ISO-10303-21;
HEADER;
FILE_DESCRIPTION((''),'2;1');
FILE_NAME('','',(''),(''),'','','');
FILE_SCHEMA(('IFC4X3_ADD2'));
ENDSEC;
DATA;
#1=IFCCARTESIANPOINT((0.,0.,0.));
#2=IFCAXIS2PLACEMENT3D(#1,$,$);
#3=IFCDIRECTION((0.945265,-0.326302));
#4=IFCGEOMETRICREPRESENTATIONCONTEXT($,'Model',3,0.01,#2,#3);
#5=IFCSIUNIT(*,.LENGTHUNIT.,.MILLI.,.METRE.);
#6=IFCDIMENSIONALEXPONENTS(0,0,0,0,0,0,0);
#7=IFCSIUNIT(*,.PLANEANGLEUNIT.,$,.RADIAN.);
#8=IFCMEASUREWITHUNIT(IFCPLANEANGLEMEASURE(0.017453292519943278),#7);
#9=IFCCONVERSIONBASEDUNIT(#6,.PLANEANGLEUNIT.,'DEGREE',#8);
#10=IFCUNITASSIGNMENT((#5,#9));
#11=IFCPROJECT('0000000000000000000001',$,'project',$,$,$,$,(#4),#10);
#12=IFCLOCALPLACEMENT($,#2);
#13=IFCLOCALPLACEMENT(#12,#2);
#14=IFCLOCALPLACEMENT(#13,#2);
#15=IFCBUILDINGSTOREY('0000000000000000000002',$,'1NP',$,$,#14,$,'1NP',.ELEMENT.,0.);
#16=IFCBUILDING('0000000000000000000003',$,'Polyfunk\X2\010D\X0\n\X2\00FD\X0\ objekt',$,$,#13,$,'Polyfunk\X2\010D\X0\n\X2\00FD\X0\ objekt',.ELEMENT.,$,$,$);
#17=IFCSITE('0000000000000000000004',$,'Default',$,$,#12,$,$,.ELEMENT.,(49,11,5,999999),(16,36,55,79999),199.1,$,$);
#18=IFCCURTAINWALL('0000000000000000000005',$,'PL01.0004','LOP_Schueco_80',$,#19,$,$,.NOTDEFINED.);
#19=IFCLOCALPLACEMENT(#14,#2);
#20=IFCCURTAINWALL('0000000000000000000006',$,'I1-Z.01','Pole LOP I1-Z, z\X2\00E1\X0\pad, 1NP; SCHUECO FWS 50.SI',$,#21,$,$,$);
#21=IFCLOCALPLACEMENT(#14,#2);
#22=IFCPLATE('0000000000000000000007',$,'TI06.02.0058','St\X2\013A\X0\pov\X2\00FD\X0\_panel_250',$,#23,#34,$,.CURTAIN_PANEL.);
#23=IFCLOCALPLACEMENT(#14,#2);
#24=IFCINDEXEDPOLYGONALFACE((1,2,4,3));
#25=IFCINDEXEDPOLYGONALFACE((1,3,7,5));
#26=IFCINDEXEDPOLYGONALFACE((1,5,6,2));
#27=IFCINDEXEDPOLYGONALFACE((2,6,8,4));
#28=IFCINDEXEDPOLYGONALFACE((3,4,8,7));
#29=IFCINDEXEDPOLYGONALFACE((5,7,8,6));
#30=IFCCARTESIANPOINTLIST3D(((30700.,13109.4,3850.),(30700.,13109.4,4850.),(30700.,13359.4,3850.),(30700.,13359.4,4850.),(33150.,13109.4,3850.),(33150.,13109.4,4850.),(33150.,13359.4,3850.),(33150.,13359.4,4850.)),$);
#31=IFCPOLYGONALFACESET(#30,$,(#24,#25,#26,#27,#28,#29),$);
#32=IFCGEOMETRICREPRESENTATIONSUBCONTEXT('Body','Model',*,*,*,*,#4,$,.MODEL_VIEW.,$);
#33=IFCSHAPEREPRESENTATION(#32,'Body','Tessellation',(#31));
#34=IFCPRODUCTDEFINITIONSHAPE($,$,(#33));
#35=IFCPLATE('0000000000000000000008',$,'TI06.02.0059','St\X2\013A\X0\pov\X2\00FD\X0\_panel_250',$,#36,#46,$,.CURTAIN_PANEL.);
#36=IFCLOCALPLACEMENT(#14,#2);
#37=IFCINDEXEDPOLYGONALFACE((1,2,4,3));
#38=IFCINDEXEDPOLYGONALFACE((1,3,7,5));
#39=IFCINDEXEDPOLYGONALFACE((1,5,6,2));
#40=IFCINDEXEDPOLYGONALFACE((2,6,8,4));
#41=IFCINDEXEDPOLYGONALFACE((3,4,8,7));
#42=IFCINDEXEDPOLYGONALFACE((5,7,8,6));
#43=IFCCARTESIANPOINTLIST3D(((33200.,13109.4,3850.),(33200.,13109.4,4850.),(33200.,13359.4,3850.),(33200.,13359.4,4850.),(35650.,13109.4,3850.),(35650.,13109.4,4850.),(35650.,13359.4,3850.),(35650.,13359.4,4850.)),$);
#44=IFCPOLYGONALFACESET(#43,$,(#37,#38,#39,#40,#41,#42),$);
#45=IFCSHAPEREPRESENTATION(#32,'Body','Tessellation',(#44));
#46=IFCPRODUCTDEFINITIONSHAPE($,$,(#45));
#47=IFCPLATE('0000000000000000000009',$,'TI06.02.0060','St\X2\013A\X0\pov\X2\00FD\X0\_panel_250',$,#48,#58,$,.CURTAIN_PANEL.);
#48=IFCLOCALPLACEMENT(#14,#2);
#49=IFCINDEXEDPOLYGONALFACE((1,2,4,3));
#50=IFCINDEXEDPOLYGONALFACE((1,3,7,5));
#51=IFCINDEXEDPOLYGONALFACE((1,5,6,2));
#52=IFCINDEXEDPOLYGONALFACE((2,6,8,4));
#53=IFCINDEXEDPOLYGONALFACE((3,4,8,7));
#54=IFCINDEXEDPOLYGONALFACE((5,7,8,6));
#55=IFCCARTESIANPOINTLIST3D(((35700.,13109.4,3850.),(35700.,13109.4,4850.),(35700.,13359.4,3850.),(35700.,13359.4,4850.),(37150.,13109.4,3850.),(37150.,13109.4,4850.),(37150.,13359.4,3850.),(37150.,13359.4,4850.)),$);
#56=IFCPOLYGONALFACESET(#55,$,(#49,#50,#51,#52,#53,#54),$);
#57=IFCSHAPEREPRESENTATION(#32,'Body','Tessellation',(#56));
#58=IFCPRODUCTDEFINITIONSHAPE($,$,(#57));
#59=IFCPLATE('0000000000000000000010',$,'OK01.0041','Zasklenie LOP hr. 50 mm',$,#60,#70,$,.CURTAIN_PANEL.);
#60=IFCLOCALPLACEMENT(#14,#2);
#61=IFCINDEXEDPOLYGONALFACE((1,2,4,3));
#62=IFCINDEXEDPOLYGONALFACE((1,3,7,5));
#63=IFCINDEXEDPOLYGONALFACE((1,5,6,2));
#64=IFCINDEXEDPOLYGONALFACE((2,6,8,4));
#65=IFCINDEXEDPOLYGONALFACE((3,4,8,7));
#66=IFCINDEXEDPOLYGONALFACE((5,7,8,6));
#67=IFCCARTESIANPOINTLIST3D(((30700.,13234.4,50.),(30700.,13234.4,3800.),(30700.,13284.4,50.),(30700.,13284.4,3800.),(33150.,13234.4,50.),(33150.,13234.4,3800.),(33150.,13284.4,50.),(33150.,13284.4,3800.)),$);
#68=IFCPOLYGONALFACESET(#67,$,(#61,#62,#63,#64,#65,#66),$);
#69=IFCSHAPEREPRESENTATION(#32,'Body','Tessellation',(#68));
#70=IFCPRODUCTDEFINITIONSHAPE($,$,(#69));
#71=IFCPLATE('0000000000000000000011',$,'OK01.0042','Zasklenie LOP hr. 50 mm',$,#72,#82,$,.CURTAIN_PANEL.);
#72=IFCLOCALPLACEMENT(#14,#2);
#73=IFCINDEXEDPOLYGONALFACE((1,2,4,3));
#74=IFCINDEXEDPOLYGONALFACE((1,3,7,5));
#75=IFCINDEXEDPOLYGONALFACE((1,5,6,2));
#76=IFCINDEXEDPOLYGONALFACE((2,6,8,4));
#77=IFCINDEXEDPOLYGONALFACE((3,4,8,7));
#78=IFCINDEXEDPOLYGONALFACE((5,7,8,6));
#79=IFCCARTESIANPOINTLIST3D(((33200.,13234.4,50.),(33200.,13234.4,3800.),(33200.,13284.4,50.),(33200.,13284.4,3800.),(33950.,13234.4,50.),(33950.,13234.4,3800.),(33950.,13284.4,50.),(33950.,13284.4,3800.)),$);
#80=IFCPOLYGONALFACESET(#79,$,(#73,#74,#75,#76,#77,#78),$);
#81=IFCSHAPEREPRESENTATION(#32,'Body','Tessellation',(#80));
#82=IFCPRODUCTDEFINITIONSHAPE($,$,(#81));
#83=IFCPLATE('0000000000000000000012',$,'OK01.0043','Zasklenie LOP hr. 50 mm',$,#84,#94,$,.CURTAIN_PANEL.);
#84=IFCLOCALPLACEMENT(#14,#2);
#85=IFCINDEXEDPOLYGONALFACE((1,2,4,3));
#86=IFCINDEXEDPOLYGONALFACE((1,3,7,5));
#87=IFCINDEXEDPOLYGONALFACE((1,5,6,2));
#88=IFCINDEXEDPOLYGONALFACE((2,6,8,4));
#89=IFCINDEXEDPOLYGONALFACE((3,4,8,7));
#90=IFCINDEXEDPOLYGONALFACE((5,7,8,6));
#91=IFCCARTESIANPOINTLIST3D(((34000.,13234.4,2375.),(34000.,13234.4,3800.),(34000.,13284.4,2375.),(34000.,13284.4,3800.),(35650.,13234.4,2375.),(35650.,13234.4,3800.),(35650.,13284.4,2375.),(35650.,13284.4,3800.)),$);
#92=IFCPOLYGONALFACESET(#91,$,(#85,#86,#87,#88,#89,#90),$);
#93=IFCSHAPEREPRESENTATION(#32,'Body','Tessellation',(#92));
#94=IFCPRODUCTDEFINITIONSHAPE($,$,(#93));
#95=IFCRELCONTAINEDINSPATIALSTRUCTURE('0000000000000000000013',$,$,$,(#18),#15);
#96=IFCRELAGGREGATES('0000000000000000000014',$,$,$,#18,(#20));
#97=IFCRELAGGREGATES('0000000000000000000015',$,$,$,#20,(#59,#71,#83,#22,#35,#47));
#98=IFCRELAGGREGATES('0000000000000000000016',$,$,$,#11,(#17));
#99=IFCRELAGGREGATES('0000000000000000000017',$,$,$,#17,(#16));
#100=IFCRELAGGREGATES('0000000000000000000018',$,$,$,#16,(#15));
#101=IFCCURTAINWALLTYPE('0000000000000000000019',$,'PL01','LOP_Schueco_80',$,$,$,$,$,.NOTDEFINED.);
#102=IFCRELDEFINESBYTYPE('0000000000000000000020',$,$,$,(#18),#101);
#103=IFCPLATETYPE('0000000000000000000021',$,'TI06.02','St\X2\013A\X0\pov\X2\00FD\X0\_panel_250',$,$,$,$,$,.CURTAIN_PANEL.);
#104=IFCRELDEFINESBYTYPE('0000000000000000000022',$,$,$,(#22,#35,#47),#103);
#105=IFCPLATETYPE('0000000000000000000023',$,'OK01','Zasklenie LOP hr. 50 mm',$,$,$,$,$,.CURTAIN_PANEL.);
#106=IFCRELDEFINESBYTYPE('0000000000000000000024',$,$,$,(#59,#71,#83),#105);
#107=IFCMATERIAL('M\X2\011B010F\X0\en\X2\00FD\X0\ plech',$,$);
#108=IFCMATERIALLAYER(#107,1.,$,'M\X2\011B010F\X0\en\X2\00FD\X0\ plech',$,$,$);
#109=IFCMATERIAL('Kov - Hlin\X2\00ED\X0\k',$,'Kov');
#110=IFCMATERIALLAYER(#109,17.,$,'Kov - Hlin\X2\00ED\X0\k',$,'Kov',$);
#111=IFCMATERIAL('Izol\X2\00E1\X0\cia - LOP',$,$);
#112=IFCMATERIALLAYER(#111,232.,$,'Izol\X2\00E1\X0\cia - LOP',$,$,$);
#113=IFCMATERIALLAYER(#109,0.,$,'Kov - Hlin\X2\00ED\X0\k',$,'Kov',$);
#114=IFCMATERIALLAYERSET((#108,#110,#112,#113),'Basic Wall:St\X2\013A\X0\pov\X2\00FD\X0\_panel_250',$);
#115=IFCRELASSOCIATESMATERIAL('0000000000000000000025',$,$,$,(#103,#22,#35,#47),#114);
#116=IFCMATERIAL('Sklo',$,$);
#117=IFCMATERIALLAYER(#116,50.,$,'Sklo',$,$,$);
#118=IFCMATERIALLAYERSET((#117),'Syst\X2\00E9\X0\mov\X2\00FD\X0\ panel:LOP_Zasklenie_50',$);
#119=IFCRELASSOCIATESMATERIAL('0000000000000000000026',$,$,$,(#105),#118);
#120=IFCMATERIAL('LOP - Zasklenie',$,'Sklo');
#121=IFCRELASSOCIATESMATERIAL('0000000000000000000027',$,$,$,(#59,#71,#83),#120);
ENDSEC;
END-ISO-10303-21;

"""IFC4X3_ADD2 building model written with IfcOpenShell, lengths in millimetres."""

from ifc_helpers import new_model, entity, si_unit, converted_unit, direction, frame, frame_2d, origin, origin_2d_with_axis, place, context, subcontext, project, spatial, rectangle, extrude, source, transform, mapped, material, layer, layer_set, layer_usage, type_object, type_shapes, element, aggregate, save


model = new_model("IFC4X3_ADD2")

# Units and contexts
model_context = context("Model", 3, precision=0.01, world=origin(), true_north=direction((0.945265, -0.326302)))
body_context = subcontext(model_context, "Body", "Model", "MODEL_VIEW")
ifc_project = project(units=[si_unit("LENGTHUNIT", "METRE", prefix="MILLI"), converted_unit("PLANEANGLEUNIT", "DEGREE", entity("IfcPlaneAngleMeasure", 0.017453292519943278), si_unit("PLANEANGLEUNIT", "RADIAN"), dimensions=[0, 0, 0, 0, 0, 0, 0])], contexts=[model_context])

# Site, building, storey
site_placement = place(None, origin())
site = spatial("IfcSite", under=ifc_project, at=site_placement, Name="Default", CompositionType="ELEMENT", RefLatitude=(49, 11, 5, 999999), RefLongitude=(16, 36, 55, 79999), RefElevation=199.1)
building_placement = place(site_placement, origin())
building = spatial("IfcBuilding", under=site, at=building_placement, Name="Polyfunkčný objekt", LongName="Polyfunkčný objekt", CompositionType="ELEMENT")
storey_placement = place(building_placement, origin())
storey = spatial("IfcBuildingStorey", under=building, at=storey_placement, Name="1NP", LongName="1NP", CompositionType="ELEMENT", Elevation=0.0)

# Curtain walls, plates
curtain_wall_type = type_object("IfcCurtainWallType", Name="PL01", Description="LOP_Schueco_80", PredefinedType="NOTDEFINED")
curtain_wall_1_placement = place(storey_placement, origin())
curtain_wall_1 = element("IfcCurtainWall", 1, at=curtain_wall_1_placement, inside=storey, type_object=curtain_wall_type, Name="PL01.0004", Description="LOP_Schueco_80", PredefinedType="NOTDEFINED")
curtain_wall_2 = element("IfcCurtainWall", 2, Name="I1-Z.01", Description="Pole LOP I1-Z, západ, 1NP; SCHUECO FWS 50.SI")
aggregate(curtain_wall_1, [curtain_wall_2])
ifc_material_1 = material(Name="Měďený plech")
ifc_layer_1 = layer(ifc_material_1, 1.0, Name="Měďený plech")
ifc_material_2 = material(Name="Kov - Hliník", Category="Kov")
ifc_layer_2 = layer(ifc_material_2, 17.0, Name="Kov - Hliník", Category="Kov")
ifc_material_3 = material(Name="Izolácia - LOP")
ifc_layer_3 = layer(ifc_material_3, 232.0, Name="Izolácia - LOP")
ifc_layer_4 = layer(ifc_material_2, 0.0, Name="Kov - Hliník", Category="Kov")
ifc_layer_set_1 = layer_set([ifc_layer_1, ifc_layer_2, ifc_layer_3, ifc_layer_4], Name="Basic Wall:Stĺpový_panel_250")
ifc_layer_usage_1 = layer_usage(ifc_layer_set_1, "AXIS2", "NEGATIVE", 125.0)
plate_type_1 = type_object("IfcPlateType", Name="TI06.02", Description="Stĺpový_panel_250", PredefinedType="CURTAIN_PANEL", material=ifc_layer_set_1)
plate_1_placement = place(storey_placement, frame((30700.0, 13234.4, 3850.0)))
plate_1 = element("IfcPlate", 3, at=plate_1_placement, type_object=plate_type_1, material=ifc_layer_usage_1, Name="TI06.02.0058", Description="Stĺpový_panel_250", PredefinedType="CURTAIN_PANEL", context=body_context, shape_type="SweptSolid", body=[
    extrude(rectangle(XDim=250.0, YDim=2450.0, at=frame_2d((0.0, 0.0), x_axis=(1.0, 0.0))), frame((1225.0, 0.0, 0.0), z_axis=(0.0, 0.0, 1.0), x_axis=(0.0, 1.0, 0.0)), (0.0, 0.0, 1.0), 1000.0),
])
ifc_layer_usage_2 = layer_usage(ifc_layer_set_1, "AXIS2", "NEGATIVE", 125.0)
plate_2_placement = place(storey_placement, frame((33200.0, 13234.4, 3850.0)))
plate_2 = element("IfcPlate", 4, at=plate_2_placement, type_object=plate_type_1, material=ifc_layer_usage_2, Name="TI06.02.0059", Description="Stĺpový_panel_250", PredefinedType="CURTAIN_PANEL", context=body_context, shape_type="SweptSolid", body=[
    extrude(rectangle(XDim=250.0, YDim=2450.0, at=frame_2d((0.0, 0.0), x_axis=(1.0, 0.0))), frame((1225.0, 0.0, 0.0), z_axis=(0.0, 0.0, 1.0), x_axis=(0.0, 1.0, 0.0)), (0.0, 0.0, 1.0), 1000.0),
])
ifc_layer_usage_3 = layer_usage(ifc_layer_set_1, "AXIS2", "NEGATIVE", 125.0)
plate_3_placement = place(storey_placement, frame((35700.0, 13234.4, 3850.0)))
plate_3 = element("IfcPlate", 5, at=plate_3_placement, type_object=plate_type_1, material=ifc_layer_usage_3, Name="TI06.02.0060", Description="Stĺpový_panel_250", PredefinedType="CURTAIN_PANEL", context=body_context, shape_type="SweptSolid", body=[
    extrude(rectangle(XDim=250.0, YDim=1450.0, at=origin_2d_with_axis()), frame((725.0, 0.0, 0.0), z_axis=(0.0, 0.0, 1.0), x_axis=(0.0, 1.0, 0.0)), (0.0, 0.0, 1.0), 1000.0),
])
ifc_material_4 = material(Name="LOP - Zasklenie", Category="Sklo")
ifc_material_5 = material(Name="Sklo")
ifc_layer_5 = layer(ifc_material_5, 50.0, Name="Sklo")
ifc_layer_set_2 = layer_set([ifc_layer_5], Name="Systémový panel:LOP_Zasklenie_50")
plate_type_2 = type_object("IfcPlateType", Name="OK01", Description="Zasklenie LOP hr. 50 mm", PredefinedType="CURTAIN_PANEL", material=ifc_layer_set_2)
shared_shape_1 = source(origin(), body_context, "Body", "SweptSolid", [
    extrude(rectangle(XDim=3750.0, YDim=2450.0, at=frame_2d((-141.7, 0.0), x_axis=(1.0, 0.0))), frame((0.0, 0.0, 2016.7), z_axis=(0.0, 1.0, 0.0), x_axis=(0.0, 0.0, 1.0)), (0.0, 0.0, 1.0), 50.0),
])
plate_4_placement = place(curtain_wall_1_placement, frame((31925.0, 13234.4, 50.0)))
plate_4 = element("IfcPlate", 6, at=plate_4_placement, type_object=plate_type_2, material=ifc_material_4, Name="OK01.0041", Description="Zasklenie LOP hr. 50 mm", PredefinedType="CURTAIN_PANEL", context=body_context, shape_type="MappedRepresentation", body=[
    mapped(shared_shape_1, transform((0.0, 0.0, 0.0), scale=1.0)),
])
shared_shape_2 = source(origin(), body_context, "Body", "SweptSolid", [
    extrude(rectangle(XDim=3750.0, YDim=750.0, at=frame_2d((-141.7, 0.0), x_axis=(1.0, 0.0))), frame((0.0, 0.0, 2016.7), z_axis=(0.0, 1.0, 0.0), x_axis=(0.0, 0.0, 1.0)), (0.0, 0.0, 1.0), 50.0),
])
plate_5_placement = place(curtain_wall_1_placement, frame((33575.0, 13234.4, 50.0)))
plate_5 = element("IfcPlate", 7, at=plate_5_placement, type_object=plate_type_2, material=ifc_material_4, Name="OK01.0042", Description="Zasklenie LOP hr. 50 mm", PredefinedType="CURTAIN_PANEL", context=body_context, shape_type="MappedRepresentation", body=[
    mapped(shared_shape_2, transform((0.0, 0.0, 0.0), scale=1.0)),
])
shared_shape_3 = source(origin(), body_context, "Body", "SweptSolid", [
    extrude(rectangle(XDim=50.0, YDim=1650.0, at=origin_2d_with_axis()), frame((0.0, 25.0, 0.0), z_axis=(0.0, 0.0, 1.0), x_axis=(0.0, 1.0, 0.0)), (0.0, 0.0, 1.0), 1425.0),
])
type_shapes(plate_type_2, [shared_shape_1, shared_shape_2, shared_shape_3])
plate_6_placement = place(curtain_wall_1_placement, frame((34825.0, 13234.4, 2375.0)))
plate_6 = element("IfcPlate", 8, at=plate_6_placement, type_object=plate_type_2, material=ifc_material_4, Name="OK01.0043", Description="Zasklenie LOP hr. 50 mm", PredefinedType="CURTAIN_PANEL", context=body_context, shape_type="MappedRepresentation", body=[
    mapped(shared_shape_3, transform((0.0, 0.0, 0.0), scale=1.0)),
])
aggregate(curtain_wall_2, [plate_4, plate_5, plate_6, plate_1, plate_2, plate_3])

save(model, "model.ifc")
